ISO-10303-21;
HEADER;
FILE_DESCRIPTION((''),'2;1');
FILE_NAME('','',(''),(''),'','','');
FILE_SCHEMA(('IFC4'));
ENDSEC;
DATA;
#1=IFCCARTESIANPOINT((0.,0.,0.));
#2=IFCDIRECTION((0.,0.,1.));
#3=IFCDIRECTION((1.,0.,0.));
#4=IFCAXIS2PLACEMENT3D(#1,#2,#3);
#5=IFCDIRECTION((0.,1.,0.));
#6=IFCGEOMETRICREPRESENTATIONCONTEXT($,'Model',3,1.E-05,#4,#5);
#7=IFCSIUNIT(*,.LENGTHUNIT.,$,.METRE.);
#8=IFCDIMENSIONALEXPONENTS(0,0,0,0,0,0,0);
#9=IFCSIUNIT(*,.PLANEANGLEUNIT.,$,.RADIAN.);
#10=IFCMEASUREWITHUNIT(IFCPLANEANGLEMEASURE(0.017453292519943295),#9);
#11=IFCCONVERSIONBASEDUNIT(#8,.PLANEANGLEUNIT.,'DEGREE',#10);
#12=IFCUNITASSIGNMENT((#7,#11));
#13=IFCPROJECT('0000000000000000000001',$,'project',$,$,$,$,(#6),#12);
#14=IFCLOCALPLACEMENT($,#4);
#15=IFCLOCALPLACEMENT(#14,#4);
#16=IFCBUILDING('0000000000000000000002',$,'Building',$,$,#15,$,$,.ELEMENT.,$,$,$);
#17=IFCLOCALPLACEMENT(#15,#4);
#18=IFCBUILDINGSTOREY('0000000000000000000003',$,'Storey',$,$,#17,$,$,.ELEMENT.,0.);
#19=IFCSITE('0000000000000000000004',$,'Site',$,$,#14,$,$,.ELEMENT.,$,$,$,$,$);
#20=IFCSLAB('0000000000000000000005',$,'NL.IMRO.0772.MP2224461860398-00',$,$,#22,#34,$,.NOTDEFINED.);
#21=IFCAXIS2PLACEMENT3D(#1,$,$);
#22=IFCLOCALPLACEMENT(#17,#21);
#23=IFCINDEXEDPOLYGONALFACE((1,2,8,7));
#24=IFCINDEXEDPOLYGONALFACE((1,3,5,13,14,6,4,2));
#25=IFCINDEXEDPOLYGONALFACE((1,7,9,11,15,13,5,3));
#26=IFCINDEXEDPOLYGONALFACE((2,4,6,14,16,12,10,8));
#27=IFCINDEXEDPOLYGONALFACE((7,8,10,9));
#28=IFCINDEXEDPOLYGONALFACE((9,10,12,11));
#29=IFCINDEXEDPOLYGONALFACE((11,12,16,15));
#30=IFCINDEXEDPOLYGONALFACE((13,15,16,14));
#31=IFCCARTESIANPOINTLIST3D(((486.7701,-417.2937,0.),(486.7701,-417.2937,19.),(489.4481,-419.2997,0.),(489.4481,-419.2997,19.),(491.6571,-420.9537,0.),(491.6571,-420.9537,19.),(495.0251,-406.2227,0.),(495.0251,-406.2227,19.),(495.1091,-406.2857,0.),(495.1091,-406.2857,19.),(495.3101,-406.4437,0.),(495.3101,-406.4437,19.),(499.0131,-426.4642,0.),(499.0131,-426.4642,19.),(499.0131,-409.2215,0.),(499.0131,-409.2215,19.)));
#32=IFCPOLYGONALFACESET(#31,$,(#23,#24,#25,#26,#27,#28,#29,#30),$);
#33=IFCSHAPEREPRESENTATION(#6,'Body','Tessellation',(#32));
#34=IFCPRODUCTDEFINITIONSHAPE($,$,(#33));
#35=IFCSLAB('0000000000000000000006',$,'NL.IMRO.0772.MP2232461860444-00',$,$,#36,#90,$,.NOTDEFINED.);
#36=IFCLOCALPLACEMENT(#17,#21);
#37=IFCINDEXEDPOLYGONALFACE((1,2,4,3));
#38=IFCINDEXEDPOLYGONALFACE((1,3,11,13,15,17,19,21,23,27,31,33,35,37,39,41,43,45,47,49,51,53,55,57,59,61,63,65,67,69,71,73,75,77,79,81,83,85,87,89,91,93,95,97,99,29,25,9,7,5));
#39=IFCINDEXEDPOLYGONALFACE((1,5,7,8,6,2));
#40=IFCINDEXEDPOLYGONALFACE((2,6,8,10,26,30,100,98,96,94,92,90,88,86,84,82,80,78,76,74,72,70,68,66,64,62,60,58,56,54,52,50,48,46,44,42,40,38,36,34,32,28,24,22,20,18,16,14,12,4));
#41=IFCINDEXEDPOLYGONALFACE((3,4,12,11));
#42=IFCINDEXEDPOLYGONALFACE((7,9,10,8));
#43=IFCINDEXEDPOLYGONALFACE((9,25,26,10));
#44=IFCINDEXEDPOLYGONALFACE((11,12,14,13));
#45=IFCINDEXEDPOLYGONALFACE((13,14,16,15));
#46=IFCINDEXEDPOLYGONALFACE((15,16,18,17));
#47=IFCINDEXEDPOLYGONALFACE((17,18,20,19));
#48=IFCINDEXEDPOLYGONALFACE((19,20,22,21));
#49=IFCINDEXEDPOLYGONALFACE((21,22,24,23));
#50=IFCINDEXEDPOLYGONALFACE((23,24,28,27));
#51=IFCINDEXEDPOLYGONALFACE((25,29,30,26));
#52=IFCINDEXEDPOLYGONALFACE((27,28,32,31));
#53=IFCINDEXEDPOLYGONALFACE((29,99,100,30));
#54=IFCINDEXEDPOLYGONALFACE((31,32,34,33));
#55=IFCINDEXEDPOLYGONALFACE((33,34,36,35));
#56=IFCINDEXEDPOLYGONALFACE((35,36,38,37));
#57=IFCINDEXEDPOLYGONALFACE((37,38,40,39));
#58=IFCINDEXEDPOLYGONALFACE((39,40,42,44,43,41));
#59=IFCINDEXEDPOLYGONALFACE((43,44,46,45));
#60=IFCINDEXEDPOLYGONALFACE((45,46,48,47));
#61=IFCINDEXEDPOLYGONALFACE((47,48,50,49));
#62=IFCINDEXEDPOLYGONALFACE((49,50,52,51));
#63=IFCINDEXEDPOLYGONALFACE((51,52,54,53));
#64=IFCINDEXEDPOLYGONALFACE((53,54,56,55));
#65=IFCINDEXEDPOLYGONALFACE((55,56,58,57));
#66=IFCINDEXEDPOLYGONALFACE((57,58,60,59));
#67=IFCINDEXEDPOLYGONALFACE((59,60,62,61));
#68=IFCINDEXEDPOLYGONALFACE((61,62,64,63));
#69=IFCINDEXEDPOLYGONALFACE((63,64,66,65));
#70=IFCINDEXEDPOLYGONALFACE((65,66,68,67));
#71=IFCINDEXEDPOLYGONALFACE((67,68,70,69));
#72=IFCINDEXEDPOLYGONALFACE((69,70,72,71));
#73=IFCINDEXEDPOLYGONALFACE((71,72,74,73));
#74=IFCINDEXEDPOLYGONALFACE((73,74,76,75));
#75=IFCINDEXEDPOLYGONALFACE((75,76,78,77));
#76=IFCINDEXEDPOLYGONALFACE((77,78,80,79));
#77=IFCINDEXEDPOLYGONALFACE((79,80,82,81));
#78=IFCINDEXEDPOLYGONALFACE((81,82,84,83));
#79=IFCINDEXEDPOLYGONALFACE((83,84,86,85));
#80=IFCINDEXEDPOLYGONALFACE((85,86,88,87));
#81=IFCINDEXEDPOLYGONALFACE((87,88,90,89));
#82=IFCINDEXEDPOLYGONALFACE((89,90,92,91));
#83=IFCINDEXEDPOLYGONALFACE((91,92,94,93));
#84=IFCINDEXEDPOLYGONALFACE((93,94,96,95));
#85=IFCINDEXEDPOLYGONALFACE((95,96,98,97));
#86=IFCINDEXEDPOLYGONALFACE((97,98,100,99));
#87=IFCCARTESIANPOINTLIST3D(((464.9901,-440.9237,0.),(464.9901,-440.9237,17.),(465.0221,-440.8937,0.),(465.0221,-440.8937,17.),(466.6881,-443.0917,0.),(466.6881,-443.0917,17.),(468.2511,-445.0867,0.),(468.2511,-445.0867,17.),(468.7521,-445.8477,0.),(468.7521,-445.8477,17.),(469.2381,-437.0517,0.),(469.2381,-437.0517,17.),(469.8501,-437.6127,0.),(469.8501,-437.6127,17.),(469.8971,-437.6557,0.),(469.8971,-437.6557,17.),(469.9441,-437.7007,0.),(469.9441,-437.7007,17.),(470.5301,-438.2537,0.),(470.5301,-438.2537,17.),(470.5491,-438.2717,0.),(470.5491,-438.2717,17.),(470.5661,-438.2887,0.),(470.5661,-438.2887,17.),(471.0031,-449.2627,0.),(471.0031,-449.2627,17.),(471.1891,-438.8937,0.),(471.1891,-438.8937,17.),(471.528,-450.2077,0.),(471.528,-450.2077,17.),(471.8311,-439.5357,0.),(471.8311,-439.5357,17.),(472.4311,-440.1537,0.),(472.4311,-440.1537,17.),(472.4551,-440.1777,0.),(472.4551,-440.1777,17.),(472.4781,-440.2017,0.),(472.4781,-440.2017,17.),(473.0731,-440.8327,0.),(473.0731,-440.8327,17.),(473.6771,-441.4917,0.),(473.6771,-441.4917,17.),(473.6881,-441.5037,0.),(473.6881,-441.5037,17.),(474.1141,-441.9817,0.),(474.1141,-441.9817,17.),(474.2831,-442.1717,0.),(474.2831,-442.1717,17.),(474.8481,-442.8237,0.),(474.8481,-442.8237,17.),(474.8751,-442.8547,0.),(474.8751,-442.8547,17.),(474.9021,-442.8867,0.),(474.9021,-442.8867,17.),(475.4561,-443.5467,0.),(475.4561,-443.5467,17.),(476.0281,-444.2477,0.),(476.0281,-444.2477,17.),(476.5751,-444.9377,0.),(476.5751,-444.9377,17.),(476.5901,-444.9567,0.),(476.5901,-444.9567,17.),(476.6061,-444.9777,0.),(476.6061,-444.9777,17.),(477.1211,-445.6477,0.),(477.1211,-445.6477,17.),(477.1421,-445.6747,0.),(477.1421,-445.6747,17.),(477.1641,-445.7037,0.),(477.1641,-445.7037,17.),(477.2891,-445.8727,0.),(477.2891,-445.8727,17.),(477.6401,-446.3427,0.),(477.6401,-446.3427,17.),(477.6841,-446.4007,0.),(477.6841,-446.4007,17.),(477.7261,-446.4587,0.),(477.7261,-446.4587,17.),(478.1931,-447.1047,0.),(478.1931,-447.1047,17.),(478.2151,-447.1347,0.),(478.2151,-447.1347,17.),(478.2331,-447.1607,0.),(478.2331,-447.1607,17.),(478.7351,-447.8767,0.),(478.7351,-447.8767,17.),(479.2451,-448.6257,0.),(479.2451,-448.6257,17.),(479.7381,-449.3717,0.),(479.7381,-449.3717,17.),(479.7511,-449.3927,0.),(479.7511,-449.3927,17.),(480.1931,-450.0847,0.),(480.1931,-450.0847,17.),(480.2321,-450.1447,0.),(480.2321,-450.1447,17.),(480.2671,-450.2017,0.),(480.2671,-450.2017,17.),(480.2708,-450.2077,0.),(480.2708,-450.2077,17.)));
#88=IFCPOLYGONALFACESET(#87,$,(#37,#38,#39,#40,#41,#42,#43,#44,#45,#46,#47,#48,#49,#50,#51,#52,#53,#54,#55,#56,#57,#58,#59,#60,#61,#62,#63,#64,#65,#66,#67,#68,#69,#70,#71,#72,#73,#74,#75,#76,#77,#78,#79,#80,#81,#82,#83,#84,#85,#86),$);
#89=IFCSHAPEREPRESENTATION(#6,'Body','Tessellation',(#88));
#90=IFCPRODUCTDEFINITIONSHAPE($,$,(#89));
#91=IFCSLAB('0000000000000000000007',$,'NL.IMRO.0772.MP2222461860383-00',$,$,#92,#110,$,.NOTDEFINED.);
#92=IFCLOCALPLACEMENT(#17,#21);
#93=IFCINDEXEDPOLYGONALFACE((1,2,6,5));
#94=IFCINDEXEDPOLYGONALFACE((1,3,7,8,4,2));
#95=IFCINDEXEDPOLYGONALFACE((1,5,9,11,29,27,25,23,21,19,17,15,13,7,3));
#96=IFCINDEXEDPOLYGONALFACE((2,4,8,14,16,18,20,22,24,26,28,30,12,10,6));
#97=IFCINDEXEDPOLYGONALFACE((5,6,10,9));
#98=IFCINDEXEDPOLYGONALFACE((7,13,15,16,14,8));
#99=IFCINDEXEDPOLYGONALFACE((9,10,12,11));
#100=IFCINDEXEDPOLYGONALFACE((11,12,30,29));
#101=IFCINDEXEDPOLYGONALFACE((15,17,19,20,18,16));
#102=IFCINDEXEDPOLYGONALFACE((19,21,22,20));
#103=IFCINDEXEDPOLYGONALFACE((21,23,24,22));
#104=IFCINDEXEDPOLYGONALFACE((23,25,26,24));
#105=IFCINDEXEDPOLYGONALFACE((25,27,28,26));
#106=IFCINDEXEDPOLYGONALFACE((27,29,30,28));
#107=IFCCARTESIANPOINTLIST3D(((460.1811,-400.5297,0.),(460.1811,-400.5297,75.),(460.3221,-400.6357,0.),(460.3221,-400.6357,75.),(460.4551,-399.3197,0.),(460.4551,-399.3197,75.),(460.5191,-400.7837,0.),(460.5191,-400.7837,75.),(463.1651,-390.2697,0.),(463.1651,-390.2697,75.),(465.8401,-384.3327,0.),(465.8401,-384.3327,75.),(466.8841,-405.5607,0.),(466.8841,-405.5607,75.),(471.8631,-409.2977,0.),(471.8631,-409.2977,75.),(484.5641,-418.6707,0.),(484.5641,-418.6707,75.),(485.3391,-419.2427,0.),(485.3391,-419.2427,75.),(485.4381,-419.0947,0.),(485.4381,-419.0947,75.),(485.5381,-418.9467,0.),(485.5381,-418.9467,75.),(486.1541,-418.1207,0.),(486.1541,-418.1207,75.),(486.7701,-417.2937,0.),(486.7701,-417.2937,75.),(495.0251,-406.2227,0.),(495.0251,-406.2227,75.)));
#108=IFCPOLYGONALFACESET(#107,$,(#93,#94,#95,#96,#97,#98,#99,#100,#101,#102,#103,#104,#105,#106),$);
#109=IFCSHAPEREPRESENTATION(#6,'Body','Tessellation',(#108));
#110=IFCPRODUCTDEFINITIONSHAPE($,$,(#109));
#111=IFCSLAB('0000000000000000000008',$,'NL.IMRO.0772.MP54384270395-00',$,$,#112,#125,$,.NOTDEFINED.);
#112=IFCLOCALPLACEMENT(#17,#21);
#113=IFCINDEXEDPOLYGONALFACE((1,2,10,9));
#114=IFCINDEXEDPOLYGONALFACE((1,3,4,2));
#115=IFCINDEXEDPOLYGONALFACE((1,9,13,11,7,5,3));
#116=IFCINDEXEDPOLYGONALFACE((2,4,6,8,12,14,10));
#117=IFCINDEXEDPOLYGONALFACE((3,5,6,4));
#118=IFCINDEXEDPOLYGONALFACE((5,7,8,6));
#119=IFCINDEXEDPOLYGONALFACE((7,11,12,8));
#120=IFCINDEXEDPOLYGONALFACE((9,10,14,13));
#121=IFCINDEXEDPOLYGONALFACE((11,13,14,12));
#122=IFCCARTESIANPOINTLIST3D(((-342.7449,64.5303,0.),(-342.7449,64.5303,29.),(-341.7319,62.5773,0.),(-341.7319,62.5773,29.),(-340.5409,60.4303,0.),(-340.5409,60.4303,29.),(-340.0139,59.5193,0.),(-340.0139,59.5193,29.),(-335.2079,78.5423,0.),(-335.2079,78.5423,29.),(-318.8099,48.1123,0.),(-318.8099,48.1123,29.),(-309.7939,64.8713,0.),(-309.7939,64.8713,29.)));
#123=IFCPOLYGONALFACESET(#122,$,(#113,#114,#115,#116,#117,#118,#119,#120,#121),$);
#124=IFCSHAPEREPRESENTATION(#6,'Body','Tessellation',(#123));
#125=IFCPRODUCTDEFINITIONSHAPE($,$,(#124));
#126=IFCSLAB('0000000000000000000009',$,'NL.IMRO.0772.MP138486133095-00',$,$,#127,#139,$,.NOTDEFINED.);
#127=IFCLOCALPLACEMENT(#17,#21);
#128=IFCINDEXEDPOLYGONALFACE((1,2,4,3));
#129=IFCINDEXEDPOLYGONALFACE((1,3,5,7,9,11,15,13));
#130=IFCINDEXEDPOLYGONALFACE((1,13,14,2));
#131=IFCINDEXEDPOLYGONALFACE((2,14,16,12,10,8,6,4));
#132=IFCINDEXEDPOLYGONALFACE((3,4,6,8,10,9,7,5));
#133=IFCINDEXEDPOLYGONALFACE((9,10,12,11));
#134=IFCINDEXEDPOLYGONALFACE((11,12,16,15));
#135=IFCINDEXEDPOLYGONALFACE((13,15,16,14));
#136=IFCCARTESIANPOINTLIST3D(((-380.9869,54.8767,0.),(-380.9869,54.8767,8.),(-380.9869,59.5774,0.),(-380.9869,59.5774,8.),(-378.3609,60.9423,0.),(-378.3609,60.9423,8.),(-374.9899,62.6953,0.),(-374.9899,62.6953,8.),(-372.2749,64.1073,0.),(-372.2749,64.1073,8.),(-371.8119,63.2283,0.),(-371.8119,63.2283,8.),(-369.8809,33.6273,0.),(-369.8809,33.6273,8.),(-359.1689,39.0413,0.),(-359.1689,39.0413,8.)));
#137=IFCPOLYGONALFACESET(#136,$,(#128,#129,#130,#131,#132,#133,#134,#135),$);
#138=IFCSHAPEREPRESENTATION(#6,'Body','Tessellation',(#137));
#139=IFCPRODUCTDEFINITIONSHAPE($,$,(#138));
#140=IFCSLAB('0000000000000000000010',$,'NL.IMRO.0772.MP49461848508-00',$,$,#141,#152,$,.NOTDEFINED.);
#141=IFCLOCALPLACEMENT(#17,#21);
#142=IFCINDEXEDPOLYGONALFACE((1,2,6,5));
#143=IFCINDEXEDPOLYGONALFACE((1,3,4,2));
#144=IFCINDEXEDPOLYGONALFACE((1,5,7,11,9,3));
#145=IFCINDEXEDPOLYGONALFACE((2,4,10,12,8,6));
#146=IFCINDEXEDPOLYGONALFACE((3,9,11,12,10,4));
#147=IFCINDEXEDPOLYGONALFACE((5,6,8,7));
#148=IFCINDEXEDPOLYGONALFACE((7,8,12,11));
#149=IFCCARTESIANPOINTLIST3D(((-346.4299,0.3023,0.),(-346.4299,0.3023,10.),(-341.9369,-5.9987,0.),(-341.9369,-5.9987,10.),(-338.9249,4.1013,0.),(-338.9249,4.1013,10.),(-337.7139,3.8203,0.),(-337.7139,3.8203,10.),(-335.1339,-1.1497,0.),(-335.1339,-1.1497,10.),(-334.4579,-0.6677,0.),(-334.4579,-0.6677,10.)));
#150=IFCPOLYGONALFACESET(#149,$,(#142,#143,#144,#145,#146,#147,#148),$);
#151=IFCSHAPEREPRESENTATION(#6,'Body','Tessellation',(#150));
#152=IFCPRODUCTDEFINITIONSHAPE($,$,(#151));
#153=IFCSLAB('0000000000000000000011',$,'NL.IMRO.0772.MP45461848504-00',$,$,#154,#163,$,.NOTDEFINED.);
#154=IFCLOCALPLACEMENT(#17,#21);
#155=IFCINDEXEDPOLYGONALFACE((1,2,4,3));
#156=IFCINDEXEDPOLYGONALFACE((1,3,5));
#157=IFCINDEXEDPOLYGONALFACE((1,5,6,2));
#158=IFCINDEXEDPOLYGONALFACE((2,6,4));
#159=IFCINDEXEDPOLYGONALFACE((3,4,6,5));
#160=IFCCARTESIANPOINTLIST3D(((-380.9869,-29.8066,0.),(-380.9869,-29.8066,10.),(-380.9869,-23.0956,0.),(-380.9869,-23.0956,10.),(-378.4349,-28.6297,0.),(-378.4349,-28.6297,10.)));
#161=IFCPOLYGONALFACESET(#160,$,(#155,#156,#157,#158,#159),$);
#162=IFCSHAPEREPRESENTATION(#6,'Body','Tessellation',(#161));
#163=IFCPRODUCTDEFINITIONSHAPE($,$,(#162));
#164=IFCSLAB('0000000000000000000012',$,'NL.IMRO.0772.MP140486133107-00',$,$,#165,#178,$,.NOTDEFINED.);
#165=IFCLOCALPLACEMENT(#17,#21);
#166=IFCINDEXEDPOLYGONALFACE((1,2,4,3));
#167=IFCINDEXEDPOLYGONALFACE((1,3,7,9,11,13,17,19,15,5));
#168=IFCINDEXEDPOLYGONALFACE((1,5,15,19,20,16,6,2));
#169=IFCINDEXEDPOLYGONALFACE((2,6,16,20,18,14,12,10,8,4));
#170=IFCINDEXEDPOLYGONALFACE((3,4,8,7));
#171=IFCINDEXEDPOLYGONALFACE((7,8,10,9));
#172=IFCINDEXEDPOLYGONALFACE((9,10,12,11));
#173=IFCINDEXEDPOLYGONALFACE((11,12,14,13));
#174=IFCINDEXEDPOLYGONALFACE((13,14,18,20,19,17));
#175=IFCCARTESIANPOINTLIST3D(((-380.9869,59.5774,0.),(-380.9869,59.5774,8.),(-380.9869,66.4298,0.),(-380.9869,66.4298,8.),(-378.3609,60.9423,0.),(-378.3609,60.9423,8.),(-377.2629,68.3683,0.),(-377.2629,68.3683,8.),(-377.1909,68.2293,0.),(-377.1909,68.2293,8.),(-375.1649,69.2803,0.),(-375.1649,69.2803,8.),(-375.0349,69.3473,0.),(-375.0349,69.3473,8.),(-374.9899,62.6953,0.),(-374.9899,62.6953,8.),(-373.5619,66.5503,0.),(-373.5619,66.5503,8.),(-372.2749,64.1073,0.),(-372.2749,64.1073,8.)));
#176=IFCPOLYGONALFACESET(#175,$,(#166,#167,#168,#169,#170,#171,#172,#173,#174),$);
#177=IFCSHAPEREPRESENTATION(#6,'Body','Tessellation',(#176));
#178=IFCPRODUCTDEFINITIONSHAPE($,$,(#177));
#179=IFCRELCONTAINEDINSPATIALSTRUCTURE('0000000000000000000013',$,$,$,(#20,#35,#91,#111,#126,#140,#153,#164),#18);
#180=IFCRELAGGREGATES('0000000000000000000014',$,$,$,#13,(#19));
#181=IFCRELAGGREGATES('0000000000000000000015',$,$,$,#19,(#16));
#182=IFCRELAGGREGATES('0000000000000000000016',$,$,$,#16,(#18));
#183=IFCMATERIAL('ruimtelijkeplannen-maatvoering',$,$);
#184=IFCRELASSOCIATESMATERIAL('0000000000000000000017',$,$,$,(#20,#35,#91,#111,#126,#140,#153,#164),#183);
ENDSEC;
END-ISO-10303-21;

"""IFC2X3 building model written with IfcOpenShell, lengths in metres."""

from ifc_helpers import new_model, entity, si_unit, converted_unit, direction, origin_with_axes, place, context, project, spatial, polyline, outline, extrude, material, element, save


model = new_model("IFC2X3")

# Units and contexts
model_context = context("Model", 3, precision=1e-05, world=origin_with_axes(), true_north=direction((0.0, 1.0, 0.0)))
ifc_project = project(units=[si_unit("LENGTHUNIT", "METRE"), converted_unit("PLANEANGLEUNIT", "DEGREE", entity("IfcPlaneAngleMeasure", 0.017453292519943295), si_unit("PLANEANGLEUNIT", "RADIAN"), dimensions=[0, 0, 0, 0, 0, 0, 0])], contexts=[model_context])

# Site, building, storey
site_placement = place(None, origin_with_axes())
site = spatial("IfcSite", under=ifc_project, at=site_placement, Name="Site", CompositionType="ELEMENT")
building_placement = place(site_placement, origin_with_axes())
building = spatial("IfcBuilding", under=site, at=building_placement, Name="Building", CompositionType="ELEMENT")
storey_placement = place(building_placement, origin_with_axes())
storey = spatial("IfcBuildingStorey", under=building, at=storey_placement, Name="Storey", CompositionType="ELEMENT", Elevation=0.0)

# Slabs
ifc_material = material(Name="ruimtelijkeplannen-maatvoering")
slab_1_placement = place(storey_placement, origin_with_axes())
element("IfcSlab", 1, at=slab_1_placement, inside=storey, material=ifc_material, Name="NL.IMRO.0772.MP2224461860398-00", PredefinedType="NOTDEFINED", context=model_context, shape_type="SweptSolid", body=[
    extrude(outline(polyline([(491.6571, -420.9537), (489.4481, -419.2997), (486.7701, -417.2937), (495.0251, -406.2227), (495.1091, -406.2857), (495.3101, -406.4437), (499.0131, -409.2215), (499.0131, -426.4642), (491.6571, -420.9537)])), origin_with_axes(), (0.0, 0.0, 1.0), 19.0),
])
slab_2_placement = place(storey_placement, origin_with_axes())
element("IfcSlab", 2, at=slab_2_placement, inside=storey, material=ifc_material, Name="NL.IMRO.0772.MP2232461860444-00", PredefinedType="NOTDEFINED", context=model_context, shape_type="SweptSolid", body=[
    extrude(outline(polyline([(471.0031, -449.2627), (468.7521, -445.8477), (468.2511, -445.0867), (466.6881, -443.0917), (464.9901, -440.9237), (465.0221, -440.8937), (469.2381, -437.0517), (469.8501, -437.6127), (469.8971, -437.6557), (469.9441, -437.7007), (470.5301, -438.2537), (470.5491, -438.2717), (470.5661, -438.2887), (471.1891, -438.8937), (471.8311, -439.5357), (472.4311, -440.1537), (472.4551, -440.1777), (472.4781, -440.2017), (473.0731, -440.8327), (473.6771, -441.4917), (473.6881, -441.5037), (474.1141, -441.9817), (474.2831, -442.1717), (474.8481, -442.8237), (474.8751, -442.8547), (474.9021, -442.8867), (475.4561, -443.5467), (476.0281, -444.2477), (476.5751, -444.9377), (476.5901, -444.9567), (476.6061, -444.9777), (477.1211, -445.6477), (477.1421, -445.6747), (477.1641, -445.7037), (477.2891, -445.8727), (477.6401, -446.3427), (477.6841, -446.4007), (477.7261, -446.4587), (478.1931, -447.1047), (478.2151, -447.1347), (478.2331, -447.1607), (478.7351, -447.8767), (479.2451, -448.6257), (479.7381, -449.3717), (479.7511, -449.3927), (480.1931, -450.0847), (480.2321, -450.1447), (480.2671, -450.2017), (480.2708, -450.2077), (471.528, -450.2077), (471.0031, -449.2627)])), origin_with_axes(), (0.0, 0.0, 1.0), 17.0),
])
slab_3_placement = place(storey_placement, origin_with_axes())
element("IfcSlab", 3, at=slab_3_placement, inside=storey, material=ifc_material, Name="NL.IMRO.0772.MP2222461860383-00", PredefinedType="NOTDEFINED", context=model_context, shape_type="SweptSolid", body=[
    extrude(outline(polyline([(486.1541, -418.1207), (485.5381, -418.9467), (485.4381, -419.0947), (485.3391, -419.2427), (484.5641, -418.6707), (471.8631, -409.2977), (466.8841, -405.5607), (460.5191, -400.7837), (460.3221, -400.6357), (460.1811, -400.5297), (460.4551, -399.3197), (463.1651, -390.2697), (465.8401, -384.3327), (495.0251, -406.2227), (486.7701, -417.2937), (486.1541, -418.1207)])), origin_with_axes(), (0.0, 0.0, 1.0), 75.0),
])
slab_4_placement = place(storey_placement, origin_with_axes())
element("IfcSlab", 4, at=slab_4_placement, inside=storey, material=ifc_material, Name="NL.IMRO.0772.MP54384270395-00", PredefinedType="NOTDEFINED", context=model_context, shape_type="SweptSolid", body=[
    extrude(outline(polyline([(-318.8099, 48.1123), (-340.0139, 59.5193), (-340.5409, 60.4303), (-341.7319, 62.5773), (-342.7449, 64.5303), (-335.2079, 78.5423), (-309.7939, 64.8713), (-318.8099, 48.1123)])), origin_with_axes(), (0.0, 0.0, 1.0), 29.0),
])
slab_5_placement = place(storey_placement, origin_with_axes())
element("IfcSlab", 5, at=slab_5_placement, inside=storey, material=ifc_material, Name="NL.IMRO.0772.MP138486133095-00", PredefinedType="NOTDEFINED", context=model_context, shape_type="SweptSolid", body=[
    extrude(outline(polyline([(-378.3609, 60.9423), (-374.9899, 62.6953), (-372.2749, 64.1073), (-371.8119, 63.2283), (-359.1689, 39.0413), (-369.8809, 33.6273), (-380.9869, 54.8767), (-380.9869, 59.5774), (-378.3609, 60.9423)])), origin_with_axes(), (0.0, 0.0, 1.0), 8.0),
])
slab_6_placement = place(storey_placement, origin_with_axes())
element("IfcSlab", 6, at=slab_6_placement, inside=storey, material=ifc_material, Name="NL.IMRO.0772.MP49461848508-00", PredefinedType="NOTDEFINED", context=model_context, shape_type="SweptSolid", body=[
    extrude(outline(polyline([(-346.4299, 0.3023), (-338.9249, 4.1013), (-337.7139, 3.8203), (-334.4579, -0.6677), (-335.1339, -1.1497), (-341.9369, -5.9987), (-346.4299, 0.3023)])), origin_with_axes(), (0.0, 0.0, 1.0), 10.0),
])
slab_7_placement = place(storey_placement, origin_with_axes())
element("IfcSlab", 7, at=slab_7_placement, inside=storey, material=ifc_material, Name="NL.IMRO.0772.MP45461848504-00", PredefinedType="NOTDEFINED", context=model_context, shape_type="SweptSolid", body=[
    extrude(outline(polyline([(-378.4349, -28.6297), (-380.9869, -29.8066), (-380.9869, -23.0956), (-378.4349, -28.6297)])), origin_with_axes(), (0.0, 0.0, 1.0), 10.0),
])
slab_8_placement = place(storey_placement, origin_with_axes())
element("IfcSlab", 8, at=slab_8_placement, inside=storey, material=ifc_material, Name="NL.IMRO.0772.MP140486133107-00", PredefinedType="NOTDEFINED", context=model_context, shape_type="SweptSolid", body=[
    extrude(outline(polyline([(-377.2629, 68.3683), (-377.1909, 68.2293), (-375.1649, 69.2803), (-375.0349, 69.3473), (-373.5619, 66.5503), (-372.2749, 64.1073), (-374.9899, 62.6953), (-378.3609, 60.9423), (-380.9869, 59.5774), (-380.9869, 66.4298), (-377.2629, 68.3683)])), origin_with_axes(), (0.0, 0.0, 1.0), 8.0),
])

save(model, "model.ifc")
